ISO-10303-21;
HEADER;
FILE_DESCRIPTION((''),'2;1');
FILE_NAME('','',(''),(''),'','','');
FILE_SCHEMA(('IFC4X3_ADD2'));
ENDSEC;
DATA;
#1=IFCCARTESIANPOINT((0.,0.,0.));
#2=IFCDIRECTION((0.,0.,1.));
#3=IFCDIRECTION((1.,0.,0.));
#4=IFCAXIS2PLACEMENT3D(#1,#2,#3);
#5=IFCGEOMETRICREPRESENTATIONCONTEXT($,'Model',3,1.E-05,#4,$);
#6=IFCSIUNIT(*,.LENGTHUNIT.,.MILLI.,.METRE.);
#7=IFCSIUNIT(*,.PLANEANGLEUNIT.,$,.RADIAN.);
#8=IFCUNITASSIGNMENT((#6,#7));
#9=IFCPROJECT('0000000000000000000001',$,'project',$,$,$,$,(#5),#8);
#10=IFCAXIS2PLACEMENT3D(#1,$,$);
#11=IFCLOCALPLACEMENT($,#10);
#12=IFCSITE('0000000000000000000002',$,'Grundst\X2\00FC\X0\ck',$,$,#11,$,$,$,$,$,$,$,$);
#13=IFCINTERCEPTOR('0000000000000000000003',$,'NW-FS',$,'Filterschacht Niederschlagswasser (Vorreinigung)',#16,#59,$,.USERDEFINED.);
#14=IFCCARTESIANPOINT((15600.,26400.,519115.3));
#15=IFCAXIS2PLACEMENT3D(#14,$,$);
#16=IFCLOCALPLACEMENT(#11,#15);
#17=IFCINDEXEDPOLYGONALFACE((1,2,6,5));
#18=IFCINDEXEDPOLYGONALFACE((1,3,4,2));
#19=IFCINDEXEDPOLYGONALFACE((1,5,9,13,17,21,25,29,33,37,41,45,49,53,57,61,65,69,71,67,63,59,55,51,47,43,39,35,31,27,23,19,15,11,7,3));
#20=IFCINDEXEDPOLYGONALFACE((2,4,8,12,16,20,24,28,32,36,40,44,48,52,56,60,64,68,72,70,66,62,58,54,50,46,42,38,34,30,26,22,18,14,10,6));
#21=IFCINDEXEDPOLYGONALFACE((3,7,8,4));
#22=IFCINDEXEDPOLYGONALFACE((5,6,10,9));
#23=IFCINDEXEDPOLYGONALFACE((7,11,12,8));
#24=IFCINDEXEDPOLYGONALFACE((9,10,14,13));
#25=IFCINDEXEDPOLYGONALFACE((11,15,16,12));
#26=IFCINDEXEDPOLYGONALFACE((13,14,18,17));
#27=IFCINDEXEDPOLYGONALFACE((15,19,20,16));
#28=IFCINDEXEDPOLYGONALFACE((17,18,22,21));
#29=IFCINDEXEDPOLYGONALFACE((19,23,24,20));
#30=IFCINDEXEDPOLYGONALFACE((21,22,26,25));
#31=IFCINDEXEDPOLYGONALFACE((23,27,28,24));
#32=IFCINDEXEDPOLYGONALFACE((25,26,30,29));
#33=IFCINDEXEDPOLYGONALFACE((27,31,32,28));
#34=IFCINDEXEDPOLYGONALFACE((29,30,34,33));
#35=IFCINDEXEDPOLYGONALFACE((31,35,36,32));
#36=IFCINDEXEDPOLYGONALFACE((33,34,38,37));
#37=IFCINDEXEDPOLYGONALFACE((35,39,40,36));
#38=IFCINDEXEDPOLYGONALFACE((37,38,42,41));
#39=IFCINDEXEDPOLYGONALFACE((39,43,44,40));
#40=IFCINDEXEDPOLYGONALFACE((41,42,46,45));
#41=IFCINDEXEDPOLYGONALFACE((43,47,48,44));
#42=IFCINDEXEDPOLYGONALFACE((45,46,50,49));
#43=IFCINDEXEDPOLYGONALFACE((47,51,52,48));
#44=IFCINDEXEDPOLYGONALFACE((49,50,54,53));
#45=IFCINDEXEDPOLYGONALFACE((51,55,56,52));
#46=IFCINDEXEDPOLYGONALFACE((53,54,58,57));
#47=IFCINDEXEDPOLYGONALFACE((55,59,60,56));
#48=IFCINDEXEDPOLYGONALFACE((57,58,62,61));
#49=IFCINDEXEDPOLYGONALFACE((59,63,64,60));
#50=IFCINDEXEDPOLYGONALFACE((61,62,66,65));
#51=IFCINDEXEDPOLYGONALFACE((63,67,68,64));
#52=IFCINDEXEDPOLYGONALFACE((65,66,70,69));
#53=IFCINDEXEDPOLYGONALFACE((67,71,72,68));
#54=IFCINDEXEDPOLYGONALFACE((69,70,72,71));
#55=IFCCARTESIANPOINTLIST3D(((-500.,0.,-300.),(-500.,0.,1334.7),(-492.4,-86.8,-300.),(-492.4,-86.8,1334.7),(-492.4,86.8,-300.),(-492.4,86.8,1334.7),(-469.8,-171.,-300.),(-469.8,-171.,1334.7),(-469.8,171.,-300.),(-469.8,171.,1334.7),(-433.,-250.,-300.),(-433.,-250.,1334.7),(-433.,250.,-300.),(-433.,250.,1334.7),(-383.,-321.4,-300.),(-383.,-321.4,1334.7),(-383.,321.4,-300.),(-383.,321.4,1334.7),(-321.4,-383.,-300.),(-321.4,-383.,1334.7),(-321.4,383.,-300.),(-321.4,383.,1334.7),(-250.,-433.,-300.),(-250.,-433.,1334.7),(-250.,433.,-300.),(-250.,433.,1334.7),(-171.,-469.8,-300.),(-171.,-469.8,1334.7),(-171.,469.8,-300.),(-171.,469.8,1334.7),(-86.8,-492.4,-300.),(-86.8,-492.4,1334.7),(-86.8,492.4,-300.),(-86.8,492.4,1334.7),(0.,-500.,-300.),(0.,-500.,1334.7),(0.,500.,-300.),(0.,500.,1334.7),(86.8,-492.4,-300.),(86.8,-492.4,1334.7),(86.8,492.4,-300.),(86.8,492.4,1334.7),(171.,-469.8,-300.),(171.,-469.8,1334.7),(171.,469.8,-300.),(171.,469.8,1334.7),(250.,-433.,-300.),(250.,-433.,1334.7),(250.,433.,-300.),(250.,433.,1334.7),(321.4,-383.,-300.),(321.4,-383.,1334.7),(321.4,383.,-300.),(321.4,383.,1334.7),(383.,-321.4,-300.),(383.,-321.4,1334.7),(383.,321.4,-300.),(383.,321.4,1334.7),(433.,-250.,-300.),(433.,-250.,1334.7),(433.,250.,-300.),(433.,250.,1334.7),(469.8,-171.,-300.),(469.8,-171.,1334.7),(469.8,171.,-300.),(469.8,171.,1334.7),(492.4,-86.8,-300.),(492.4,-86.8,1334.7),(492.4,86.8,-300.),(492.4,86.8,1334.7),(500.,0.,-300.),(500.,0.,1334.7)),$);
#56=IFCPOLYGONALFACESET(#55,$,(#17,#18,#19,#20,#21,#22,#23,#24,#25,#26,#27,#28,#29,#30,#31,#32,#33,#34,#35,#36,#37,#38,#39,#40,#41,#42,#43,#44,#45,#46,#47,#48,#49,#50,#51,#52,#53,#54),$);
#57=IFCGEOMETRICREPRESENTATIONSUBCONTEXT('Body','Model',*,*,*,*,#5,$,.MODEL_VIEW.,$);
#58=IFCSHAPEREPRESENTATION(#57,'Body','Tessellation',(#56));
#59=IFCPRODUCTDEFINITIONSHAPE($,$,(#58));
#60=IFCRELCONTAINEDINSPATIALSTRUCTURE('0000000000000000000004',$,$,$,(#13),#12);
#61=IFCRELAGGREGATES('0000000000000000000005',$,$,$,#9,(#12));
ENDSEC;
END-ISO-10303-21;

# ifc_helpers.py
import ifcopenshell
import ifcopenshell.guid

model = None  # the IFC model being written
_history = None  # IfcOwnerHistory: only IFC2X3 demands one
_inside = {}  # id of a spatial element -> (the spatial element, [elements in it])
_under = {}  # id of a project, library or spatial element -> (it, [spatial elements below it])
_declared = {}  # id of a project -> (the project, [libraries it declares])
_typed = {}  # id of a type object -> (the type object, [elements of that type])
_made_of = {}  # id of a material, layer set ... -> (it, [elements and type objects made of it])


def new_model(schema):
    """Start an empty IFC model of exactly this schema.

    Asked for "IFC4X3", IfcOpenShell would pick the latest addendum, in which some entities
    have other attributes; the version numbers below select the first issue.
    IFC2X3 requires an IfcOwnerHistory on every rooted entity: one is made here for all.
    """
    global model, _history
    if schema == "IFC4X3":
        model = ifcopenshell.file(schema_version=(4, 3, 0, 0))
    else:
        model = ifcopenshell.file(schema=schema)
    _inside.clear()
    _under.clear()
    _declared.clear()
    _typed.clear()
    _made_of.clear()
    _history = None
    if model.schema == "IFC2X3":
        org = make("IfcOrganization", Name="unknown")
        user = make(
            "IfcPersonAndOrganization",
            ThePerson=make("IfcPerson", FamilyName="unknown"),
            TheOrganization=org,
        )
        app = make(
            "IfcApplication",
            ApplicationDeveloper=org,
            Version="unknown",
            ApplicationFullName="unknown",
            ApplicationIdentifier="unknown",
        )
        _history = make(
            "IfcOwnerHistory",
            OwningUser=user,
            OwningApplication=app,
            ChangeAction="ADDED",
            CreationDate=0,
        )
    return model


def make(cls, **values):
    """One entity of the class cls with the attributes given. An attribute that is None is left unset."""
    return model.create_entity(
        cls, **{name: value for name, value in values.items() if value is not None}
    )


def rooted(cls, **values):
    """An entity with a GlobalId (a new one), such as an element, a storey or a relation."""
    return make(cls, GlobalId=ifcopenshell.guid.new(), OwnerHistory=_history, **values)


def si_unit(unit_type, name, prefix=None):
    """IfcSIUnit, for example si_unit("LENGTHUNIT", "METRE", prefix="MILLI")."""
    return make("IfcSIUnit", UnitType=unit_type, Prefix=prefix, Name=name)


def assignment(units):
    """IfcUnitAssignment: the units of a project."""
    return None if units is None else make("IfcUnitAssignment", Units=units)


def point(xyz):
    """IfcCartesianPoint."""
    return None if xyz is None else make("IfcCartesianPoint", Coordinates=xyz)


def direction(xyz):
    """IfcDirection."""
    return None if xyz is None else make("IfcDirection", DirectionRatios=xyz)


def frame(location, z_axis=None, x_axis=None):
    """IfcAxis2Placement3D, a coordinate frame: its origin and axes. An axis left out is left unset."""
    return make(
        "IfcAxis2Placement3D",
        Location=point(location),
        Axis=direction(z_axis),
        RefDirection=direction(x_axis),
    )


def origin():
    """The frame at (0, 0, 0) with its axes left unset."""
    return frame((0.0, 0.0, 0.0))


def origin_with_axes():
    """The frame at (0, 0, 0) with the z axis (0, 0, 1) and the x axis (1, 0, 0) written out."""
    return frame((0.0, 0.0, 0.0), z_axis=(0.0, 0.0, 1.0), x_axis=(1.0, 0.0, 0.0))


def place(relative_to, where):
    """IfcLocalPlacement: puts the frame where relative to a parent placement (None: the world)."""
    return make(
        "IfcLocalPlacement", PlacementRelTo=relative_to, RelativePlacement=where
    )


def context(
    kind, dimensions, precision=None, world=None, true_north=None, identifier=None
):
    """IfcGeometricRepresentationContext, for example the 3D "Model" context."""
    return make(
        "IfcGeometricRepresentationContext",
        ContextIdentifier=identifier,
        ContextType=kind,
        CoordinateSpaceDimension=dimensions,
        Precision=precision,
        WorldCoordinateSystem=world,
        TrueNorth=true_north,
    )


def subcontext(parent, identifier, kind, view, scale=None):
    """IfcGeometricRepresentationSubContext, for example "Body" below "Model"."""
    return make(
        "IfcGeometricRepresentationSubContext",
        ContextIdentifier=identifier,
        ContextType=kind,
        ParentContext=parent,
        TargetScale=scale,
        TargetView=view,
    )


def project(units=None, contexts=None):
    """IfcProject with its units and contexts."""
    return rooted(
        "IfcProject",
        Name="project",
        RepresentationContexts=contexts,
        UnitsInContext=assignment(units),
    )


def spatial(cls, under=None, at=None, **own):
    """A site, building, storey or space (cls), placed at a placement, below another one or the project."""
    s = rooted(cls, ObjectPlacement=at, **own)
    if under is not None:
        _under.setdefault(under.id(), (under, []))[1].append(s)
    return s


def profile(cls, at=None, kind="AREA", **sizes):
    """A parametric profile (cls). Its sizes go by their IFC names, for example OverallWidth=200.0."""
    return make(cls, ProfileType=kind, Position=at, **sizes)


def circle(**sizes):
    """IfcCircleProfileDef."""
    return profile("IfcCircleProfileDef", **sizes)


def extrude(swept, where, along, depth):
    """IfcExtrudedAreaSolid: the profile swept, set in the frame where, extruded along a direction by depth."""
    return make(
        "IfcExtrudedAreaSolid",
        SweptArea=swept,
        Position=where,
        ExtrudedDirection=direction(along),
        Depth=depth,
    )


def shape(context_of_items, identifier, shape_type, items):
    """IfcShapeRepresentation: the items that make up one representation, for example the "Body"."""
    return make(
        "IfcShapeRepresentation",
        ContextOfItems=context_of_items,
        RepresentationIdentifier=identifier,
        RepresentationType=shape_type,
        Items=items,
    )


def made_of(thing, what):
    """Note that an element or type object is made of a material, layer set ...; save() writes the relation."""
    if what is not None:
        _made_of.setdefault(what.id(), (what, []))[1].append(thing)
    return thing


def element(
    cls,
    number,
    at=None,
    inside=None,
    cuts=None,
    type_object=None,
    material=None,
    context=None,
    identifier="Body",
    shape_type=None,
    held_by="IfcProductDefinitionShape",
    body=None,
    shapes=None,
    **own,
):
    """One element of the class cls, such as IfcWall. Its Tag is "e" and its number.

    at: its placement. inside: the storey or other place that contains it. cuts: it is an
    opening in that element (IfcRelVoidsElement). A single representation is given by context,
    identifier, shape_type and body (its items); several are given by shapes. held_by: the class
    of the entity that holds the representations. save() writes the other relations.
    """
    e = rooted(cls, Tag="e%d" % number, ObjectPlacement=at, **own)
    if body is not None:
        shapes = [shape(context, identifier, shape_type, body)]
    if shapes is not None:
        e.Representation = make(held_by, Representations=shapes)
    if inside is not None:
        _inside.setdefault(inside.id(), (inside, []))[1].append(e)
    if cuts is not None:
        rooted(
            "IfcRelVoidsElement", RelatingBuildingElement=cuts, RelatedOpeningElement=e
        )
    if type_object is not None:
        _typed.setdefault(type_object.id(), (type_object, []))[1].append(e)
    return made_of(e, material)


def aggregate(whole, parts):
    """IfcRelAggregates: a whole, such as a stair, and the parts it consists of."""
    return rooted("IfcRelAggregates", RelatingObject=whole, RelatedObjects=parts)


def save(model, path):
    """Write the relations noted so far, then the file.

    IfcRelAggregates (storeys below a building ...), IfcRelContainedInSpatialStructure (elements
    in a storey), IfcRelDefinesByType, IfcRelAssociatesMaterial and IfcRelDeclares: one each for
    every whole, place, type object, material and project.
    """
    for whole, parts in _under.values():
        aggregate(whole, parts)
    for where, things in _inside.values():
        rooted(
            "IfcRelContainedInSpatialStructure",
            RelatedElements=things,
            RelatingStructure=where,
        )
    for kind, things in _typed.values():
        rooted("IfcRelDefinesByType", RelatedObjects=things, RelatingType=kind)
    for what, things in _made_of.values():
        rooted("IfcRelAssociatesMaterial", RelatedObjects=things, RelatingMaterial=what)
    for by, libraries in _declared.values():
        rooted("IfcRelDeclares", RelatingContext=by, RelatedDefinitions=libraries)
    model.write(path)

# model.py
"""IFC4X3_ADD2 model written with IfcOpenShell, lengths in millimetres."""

from ifc_helpers import new_model, si_unit, frame, origin, origin_with_axes, place, context, subcontext, project, spatial, circle, extrude, element, save


model = new_model("IFC4X3_ADD2")

# Units and contexts
model_context = context("Model", 3, precision=1e-05, world=origin_with_axes())
body_context = subcontext(model_context, "Body", "Model", "MODEL_VIEW")
ifc_project = project(units=[si_unit("LENGTHUNIT", "METRE", prefix="MILLI"), si_unit("PLANEANGLEUNIT", "RADIAN")], contexts=[model_context])

# Site
site_placement = place(None, origin())
site = spatial("IfcSite", under=ifc_project, at=site_placement, Name="Grundstück")

# Interceptor
interceptor_placement = place(site_placement, frame((15600.0, 26400.0, 519115.3)))
element("IfcInterceptor", 1, at=interceptor_placement, inside=site, Name="NW-FS", ObjectType="Filterschacht Niederschlagswasser (Vorreinigung)", PredefinedType="USERDEFINED", context=body_context, shape_type="SweptSolid", body=[
    extrude(circle(Radius=500.0), frame((0.0, 0.0, -300.0)), (0.0, 0.0, 1.0), 1634.7),
])

save(model, "model.ifc")
